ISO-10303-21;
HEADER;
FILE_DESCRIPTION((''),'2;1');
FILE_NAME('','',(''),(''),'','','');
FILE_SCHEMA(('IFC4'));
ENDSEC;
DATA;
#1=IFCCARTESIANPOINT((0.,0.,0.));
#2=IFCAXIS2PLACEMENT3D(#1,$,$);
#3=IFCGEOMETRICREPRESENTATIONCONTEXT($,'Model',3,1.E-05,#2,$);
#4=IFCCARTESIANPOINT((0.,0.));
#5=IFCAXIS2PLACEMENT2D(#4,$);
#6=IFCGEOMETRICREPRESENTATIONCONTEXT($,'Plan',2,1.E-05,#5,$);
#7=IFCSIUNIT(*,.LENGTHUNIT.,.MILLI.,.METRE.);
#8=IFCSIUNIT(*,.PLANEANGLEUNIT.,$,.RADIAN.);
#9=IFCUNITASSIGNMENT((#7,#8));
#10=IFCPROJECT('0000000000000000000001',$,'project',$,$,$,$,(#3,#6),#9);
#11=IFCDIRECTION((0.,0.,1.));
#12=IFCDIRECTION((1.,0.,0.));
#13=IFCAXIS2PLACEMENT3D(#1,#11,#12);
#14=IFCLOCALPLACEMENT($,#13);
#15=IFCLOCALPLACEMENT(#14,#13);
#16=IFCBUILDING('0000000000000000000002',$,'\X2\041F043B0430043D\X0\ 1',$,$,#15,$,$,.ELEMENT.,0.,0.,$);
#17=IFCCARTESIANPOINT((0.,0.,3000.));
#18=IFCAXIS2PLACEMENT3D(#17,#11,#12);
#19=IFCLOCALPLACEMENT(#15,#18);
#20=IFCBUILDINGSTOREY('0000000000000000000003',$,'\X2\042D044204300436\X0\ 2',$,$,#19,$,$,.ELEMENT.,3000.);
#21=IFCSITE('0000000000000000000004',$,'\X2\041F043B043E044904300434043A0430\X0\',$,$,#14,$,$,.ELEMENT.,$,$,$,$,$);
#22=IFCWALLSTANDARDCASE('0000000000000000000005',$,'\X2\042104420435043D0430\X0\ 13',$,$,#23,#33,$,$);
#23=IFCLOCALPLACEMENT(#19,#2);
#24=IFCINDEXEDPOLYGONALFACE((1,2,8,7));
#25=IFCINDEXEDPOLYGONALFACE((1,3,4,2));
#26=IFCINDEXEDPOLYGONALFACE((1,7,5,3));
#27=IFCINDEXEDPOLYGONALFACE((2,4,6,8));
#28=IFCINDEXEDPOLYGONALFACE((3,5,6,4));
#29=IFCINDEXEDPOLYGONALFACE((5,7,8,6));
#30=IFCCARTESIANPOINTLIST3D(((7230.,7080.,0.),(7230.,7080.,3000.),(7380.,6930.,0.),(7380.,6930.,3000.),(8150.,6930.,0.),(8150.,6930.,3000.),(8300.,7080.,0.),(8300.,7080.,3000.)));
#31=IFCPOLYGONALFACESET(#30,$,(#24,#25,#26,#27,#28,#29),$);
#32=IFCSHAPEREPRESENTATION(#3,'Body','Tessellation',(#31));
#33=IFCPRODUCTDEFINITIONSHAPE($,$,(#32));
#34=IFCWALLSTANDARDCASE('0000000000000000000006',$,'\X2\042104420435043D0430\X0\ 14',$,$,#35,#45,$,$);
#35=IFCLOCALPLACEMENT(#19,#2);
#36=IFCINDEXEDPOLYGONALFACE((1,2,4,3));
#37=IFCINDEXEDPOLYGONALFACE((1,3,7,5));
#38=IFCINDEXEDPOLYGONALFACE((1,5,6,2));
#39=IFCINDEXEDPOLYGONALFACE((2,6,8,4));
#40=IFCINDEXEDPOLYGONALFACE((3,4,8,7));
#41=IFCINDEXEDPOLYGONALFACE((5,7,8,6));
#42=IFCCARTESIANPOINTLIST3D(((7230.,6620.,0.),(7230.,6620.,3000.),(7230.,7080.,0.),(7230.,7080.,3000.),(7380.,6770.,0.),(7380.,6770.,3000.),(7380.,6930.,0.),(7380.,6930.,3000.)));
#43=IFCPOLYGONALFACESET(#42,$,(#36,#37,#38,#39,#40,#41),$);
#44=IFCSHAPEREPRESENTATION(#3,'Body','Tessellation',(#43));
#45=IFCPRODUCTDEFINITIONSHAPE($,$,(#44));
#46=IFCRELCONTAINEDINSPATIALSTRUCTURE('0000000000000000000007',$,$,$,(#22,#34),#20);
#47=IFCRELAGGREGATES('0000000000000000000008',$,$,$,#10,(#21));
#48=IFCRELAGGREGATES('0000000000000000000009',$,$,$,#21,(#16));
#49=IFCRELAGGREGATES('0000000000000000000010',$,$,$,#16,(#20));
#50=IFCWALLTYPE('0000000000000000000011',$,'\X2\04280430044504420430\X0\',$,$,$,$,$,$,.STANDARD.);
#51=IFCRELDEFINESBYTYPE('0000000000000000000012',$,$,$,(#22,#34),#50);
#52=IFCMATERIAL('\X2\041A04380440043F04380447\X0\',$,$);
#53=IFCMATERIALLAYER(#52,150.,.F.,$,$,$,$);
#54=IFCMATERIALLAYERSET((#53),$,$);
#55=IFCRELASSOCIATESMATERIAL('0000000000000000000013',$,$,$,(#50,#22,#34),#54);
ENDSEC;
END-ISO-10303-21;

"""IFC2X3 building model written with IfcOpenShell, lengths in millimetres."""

from ifc_helpers import new_model, si_unit, frame, origin, origin_with_axes, origin_2d, place, context, project, spatial, polyline, segment, composite_curve, outline, extrude, material, layer, layer_set, layer_usage, type_object, element, save


model = new_model("IFC2X3")

# Units and contexts
model_context = context("Model", 3, precision=1e-05, world=origin())
plan_context = context("Plan", 2, precision=1e-05, world=origin_2d())
ifc_project = project(units=[si_unit("LENGTHUNIT", "METRE", prefix="MILLI"), si_unit("PLANEANGLEUNIT", "RADIAN")], contexts=[model_context, plan_context])

# Site, building, storey
site_placement = place(None, origin_with_axes())
site = spatial("IfcSite", under=ifc_project, at=site_placement, Name="Площадка", CompositionType="ELEMENT")
building_placement = place(site_placement, origin_with_axes())
building = spatial("IfcBuilding", under=site, at=building_placement, Name="План 1", CompositionType="ELEMENT", ElevationOfRefHeight=0.0, ElevationOfTerrain=0.0)
storey_placement = place(building_placement, frame((0.0, 0.0, 3000.0), z_axis=(0.0, 0.0, 1.0), x_axis=(1.0, 0.0, 0.0)))
storey = spatial("IfcBuildingStorey", under=building, at=storey_placement, Name="Этаж 2", CompositionType="ELEMENT", Elevation=3000.0)

# Walls
ifc_material_1 = material(Name="Кирпич")
ifc_layer_1 = layer(ifc_material_1, 150.0, ventilated=False)
ifc_layer_set_1 = layer_set([ifc_layer_1])
wall_type_1 = type_object("IfcWallType", Name="Шахта", PredefinedType="STANDARD", material=ifc_layer_set_1)
ifc_layer_usage_1 = layer_usage(ifc_layer_set_1, "AXIS2", "POSITIVE", 0.0)
wall_1_placement = place(storey_placement, frame((8300.0, 7080.0, 0.0), z_axis=(0.0, 0.0, 1.0), x_axis=(-1.0, 0.0, 0.0)))
element("IfcWallStandardCase", 1, at=wall_1_placement, inside=storey, type_object=wall_type_1, material=ifc_layer_usage_1, Name="Стена 13", context=model_context, shape_type="SweptSolid", body=[
    extrude(outline(composite_curve([segment(polyline([(150.0, 150.0), (0.0, 0.0)]), True, "CONTINUOUS"), segment(polyline([(0.0, 0.0), (1070.0, 0.0)]), True, "CONTINUOUS"), segment(polyline([(1070.0, 0.0), (920.0, 150.0)]), True, "CONTINUOUS"), segment(polyline([(920.0, 150.0), (150.0, 150.0)]), True, "CONTINUOUS")], self_intersect=False)), origin_with_axes(), (0.0, 0.0, 1.0), 3000.0),
])
ifc_layer_usage_2 = layer_usage(ifc_layer_set_1, "AXIS2", "POSITIVE", 0.0)
wall_2_placement = place(storey_placement, frame((7230.0, 7080.0, 0.0), z_axis=(0.0, 0.0, 1.0), x_axis=(0.0, -1.0, 0.0)))
element("IfcWallStandardCase", 2, at=wall_2_placement, inside=storey, type_object=wall_type_1, material=ifc_layer_usage_2, Name="Стена 14", context=model_context, shape_type="SweptSolid", body=[
    extrude(outline(composite_curve([segment(polyline([(150.0, 150.0), (0.0, 0.0)]), True, "CONTINUOUS"), segment(polyline([(0.0, 0.0), (460.0, 0.0)]), True, "CONTINUOUS"), segment(polyline([(460.0, 0.0), (310.0, 150.0)]), True, "CONTINUOUS"), segment(polyline([(310.0, 150.0), (150.0, 150.0)]), True, "CONTINUOUS")], self_intersect=False)), origin_with_axes(), (0.0, 0.0, 1.0), 3000.0),
])

save(model, "model.ifc")
